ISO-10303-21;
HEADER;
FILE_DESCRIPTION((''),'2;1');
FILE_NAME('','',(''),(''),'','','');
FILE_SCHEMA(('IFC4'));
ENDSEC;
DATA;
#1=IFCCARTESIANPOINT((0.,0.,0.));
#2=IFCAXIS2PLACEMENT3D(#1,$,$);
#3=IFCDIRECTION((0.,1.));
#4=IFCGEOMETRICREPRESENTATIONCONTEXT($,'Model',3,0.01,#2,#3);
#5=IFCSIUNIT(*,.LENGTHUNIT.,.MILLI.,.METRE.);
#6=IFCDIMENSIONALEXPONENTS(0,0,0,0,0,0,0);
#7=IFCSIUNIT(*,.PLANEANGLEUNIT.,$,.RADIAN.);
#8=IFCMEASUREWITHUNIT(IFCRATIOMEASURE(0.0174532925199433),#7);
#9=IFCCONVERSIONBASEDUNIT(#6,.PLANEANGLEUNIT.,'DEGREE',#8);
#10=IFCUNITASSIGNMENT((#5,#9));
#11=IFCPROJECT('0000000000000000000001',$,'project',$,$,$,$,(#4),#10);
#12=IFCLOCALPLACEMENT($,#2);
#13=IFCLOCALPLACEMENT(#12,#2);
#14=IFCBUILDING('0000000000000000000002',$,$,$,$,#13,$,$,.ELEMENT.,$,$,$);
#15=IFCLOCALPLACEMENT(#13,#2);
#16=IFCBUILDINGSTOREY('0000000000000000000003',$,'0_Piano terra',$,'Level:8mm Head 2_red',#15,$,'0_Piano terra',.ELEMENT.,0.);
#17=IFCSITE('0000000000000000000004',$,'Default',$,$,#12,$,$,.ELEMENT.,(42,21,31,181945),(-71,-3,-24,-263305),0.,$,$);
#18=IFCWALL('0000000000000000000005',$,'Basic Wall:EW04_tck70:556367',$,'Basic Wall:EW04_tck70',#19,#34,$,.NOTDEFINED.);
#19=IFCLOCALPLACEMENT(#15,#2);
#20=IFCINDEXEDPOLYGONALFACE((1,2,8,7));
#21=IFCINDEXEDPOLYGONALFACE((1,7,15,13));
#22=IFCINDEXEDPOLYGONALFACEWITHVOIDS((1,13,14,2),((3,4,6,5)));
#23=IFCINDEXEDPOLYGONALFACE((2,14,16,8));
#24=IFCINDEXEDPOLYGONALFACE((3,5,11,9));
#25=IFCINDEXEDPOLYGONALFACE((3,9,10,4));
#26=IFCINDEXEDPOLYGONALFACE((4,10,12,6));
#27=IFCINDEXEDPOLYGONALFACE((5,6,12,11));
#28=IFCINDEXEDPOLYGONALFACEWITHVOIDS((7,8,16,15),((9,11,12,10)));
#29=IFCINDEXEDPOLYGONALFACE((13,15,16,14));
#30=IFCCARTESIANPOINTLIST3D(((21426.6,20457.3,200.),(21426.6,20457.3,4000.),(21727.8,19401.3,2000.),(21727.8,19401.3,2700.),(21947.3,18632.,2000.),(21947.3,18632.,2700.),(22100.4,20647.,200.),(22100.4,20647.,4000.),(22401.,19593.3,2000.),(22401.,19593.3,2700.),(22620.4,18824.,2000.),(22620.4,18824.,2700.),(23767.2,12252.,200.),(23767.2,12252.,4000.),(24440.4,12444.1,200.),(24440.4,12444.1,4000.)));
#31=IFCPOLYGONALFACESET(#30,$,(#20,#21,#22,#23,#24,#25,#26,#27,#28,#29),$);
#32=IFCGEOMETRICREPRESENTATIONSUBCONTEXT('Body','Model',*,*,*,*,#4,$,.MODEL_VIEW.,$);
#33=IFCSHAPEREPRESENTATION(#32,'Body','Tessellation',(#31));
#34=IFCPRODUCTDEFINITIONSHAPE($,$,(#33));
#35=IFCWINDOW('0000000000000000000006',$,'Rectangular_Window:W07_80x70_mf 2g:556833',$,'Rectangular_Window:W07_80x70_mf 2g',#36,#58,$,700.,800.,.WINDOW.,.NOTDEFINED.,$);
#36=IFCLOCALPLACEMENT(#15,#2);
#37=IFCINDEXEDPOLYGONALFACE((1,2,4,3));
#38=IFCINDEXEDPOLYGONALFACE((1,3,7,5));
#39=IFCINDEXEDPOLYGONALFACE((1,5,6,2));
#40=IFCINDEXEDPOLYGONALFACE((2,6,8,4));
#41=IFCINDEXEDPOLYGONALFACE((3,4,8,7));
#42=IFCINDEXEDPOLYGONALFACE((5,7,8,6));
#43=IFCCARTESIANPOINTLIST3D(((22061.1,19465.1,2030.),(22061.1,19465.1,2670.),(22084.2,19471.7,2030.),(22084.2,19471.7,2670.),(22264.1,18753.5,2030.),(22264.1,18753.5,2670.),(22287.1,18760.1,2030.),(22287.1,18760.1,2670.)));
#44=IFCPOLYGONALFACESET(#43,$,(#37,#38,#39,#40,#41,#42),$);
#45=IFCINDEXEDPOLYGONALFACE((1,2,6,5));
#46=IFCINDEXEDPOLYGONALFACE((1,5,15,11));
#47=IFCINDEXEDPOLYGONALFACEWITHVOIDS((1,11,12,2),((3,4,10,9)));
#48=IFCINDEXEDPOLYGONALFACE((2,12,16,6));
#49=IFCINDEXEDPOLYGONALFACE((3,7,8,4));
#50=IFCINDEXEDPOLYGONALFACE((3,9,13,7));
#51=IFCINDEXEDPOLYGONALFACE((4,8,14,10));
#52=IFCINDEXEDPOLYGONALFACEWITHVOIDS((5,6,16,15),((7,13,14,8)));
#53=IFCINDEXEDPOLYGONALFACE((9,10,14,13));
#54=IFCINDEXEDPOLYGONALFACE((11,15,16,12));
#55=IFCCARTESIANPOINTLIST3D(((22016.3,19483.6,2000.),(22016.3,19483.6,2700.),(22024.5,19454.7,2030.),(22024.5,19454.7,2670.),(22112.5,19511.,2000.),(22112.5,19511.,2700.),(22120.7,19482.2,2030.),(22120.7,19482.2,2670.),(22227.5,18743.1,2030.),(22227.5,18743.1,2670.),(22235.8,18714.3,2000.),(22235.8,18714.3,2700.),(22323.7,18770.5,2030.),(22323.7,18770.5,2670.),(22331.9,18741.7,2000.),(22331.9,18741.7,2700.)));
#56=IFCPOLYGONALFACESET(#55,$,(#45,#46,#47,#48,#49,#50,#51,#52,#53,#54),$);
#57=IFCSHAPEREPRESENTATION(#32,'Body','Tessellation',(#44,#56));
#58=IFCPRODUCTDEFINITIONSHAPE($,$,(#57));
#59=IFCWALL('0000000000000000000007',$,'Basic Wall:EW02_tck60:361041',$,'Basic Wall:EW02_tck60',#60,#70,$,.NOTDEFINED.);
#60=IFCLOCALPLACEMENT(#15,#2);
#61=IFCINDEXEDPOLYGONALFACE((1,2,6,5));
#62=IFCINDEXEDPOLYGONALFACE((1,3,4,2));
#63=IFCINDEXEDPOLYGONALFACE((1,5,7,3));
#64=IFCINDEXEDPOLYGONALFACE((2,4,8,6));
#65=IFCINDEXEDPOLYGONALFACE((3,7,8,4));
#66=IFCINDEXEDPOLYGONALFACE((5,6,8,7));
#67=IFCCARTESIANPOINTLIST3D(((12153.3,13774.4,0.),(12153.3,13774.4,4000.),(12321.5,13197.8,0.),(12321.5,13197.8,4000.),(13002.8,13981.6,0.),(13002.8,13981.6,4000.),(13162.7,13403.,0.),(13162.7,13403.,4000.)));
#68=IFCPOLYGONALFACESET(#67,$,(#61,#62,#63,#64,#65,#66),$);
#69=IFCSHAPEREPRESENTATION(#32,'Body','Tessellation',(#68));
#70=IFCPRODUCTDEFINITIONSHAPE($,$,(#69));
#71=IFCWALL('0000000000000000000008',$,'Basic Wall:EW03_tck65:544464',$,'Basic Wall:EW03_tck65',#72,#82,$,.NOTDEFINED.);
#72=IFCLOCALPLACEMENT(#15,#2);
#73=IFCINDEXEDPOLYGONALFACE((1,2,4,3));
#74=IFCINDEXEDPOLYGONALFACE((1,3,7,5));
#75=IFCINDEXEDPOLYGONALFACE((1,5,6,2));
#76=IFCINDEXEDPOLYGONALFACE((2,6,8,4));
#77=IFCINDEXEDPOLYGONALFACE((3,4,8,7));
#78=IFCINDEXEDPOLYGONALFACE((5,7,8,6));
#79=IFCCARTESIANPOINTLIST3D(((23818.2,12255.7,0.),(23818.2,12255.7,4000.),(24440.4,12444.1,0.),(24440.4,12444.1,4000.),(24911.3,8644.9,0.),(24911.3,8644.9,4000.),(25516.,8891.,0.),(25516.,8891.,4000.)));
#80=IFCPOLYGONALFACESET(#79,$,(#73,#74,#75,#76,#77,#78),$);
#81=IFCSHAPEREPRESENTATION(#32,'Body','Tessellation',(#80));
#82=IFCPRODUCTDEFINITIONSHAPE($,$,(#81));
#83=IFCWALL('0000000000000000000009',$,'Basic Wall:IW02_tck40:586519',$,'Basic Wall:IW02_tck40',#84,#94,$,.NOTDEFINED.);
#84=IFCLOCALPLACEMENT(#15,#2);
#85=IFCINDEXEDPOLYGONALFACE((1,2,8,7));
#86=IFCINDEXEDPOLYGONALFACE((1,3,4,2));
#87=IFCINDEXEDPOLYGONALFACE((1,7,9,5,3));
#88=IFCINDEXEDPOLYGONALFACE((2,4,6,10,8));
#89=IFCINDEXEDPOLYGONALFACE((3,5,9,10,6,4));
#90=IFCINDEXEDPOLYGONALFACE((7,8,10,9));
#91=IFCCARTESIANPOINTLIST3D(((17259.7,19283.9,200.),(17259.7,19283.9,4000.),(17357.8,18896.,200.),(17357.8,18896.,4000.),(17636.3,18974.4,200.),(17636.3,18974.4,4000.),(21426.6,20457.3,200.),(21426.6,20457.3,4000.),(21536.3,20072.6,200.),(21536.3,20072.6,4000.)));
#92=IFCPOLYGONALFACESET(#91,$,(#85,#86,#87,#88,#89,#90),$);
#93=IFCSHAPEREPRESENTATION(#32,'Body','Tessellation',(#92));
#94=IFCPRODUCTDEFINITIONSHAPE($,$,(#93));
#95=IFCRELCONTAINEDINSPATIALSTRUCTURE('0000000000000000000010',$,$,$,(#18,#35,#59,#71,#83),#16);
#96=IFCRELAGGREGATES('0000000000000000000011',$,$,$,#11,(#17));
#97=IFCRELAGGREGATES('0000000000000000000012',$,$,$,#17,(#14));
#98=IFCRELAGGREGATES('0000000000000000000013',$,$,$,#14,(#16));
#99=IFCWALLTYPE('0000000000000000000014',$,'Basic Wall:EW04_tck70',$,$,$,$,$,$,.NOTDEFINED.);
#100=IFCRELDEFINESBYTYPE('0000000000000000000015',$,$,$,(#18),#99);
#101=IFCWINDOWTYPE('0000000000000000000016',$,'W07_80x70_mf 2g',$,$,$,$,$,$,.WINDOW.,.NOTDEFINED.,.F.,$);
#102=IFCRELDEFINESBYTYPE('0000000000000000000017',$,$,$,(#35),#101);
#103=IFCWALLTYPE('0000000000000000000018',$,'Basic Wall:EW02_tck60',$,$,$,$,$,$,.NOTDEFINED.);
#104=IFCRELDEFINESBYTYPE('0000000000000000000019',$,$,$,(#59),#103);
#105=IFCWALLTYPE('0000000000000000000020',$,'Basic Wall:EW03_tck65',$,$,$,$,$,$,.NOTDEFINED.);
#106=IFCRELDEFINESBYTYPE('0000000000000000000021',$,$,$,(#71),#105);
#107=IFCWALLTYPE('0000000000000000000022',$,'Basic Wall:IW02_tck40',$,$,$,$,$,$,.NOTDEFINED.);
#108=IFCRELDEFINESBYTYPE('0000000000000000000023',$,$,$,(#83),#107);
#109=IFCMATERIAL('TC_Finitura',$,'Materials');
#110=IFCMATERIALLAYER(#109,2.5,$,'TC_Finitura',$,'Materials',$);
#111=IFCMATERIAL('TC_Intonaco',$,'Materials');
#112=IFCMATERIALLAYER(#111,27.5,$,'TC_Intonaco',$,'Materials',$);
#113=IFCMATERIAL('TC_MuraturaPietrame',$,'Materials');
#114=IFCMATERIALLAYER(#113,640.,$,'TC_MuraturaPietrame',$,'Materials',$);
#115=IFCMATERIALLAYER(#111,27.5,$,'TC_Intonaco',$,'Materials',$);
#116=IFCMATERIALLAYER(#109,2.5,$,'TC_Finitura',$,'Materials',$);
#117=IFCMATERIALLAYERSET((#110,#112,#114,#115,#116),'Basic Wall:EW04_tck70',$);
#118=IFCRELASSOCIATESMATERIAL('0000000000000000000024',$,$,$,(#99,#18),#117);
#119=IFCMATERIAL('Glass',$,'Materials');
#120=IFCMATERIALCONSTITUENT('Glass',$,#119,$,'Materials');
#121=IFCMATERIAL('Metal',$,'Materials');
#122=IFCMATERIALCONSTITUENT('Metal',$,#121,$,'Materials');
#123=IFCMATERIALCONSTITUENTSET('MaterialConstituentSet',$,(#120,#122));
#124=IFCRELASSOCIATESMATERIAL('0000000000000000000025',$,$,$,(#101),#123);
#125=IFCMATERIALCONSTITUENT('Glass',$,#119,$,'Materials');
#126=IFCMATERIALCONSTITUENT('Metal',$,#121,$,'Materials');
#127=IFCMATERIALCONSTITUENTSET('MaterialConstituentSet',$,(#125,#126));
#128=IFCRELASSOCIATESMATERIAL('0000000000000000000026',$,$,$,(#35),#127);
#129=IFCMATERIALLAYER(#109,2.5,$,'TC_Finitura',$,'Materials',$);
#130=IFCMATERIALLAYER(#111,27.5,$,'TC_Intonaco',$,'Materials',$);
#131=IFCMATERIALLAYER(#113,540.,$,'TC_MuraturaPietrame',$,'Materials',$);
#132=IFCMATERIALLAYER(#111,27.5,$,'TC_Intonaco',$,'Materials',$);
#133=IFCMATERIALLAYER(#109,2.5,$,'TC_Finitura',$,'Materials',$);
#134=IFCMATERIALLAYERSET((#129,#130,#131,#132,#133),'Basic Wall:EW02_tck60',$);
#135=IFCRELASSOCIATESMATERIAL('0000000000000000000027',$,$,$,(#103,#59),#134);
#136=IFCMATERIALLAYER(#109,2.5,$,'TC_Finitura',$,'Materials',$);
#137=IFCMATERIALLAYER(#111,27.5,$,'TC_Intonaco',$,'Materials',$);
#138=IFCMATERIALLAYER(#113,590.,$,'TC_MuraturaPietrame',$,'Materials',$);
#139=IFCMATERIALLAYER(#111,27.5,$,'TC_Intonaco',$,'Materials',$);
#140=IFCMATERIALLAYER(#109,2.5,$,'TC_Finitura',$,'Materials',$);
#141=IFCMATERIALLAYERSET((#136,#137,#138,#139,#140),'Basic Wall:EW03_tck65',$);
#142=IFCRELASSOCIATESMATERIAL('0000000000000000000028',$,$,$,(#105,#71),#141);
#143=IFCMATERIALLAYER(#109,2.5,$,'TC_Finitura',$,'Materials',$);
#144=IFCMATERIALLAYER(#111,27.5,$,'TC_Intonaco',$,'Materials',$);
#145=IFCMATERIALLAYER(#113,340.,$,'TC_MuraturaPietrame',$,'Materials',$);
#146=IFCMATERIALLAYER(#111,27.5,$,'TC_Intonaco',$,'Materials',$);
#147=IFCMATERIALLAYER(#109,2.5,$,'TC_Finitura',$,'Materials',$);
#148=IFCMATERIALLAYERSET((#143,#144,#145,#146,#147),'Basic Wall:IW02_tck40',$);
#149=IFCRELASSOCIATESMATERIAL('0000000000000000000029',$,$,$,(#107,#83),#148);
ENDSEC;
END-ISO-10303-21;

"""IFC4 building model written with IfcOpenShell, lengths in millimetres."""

from ifc_helpers import new_model, entity, si_unit, converted_unit, direction, frame, frame_2d, origin, origin_2d_with_axis, place, context, subcontext, project, spatial, polyline, rectangle, outline, extrude, clip, halfspace, bounded_halfspace, source, transform, mapped, material, layer, layer_set, layer_usage, constituent, constituent_set, type_object, type_shapes, element, fill, save


model = new_model("IFC4")

# Units and contexts
model_context = context("Model", 3, precision=0.01, world=origin(), true_north=direction((0.0, 1.0)))
body_context = subcontext(model_context, "Body", "Model", "MODEL_VIEW")
ifc_project = project(units=[si_unit("LENGTHUNIT", "METRE", prefix="MILLI"), converted_unit("PLANEANGLEUNIT", "DEGREE", entity("IfcRatioMeasure", 0.0174532925199433), si_unit("PLANEANGLEUNIT", "RADIAN"), dimensions=[0, 0, 0, 0, 0, 0, 0])], contexts=[model_context])

# Site, building, storey
site_placement = place(None, origin())
site = spatial("IfcSite", under=ifc_project, at=site_placement, Name="Default", CompositionType="ELEMENT", RefLatitude=(42, 21, 31, 181945), RefLongitude=(-71, -3, -24, -263305), RefElevation=0.0)
building_placement = place(site_placement, origin())
building = spatial("IfcBuilding", under=site, at=building_placement, CompositionType="ELEMENT")
storey_placement = place(building_placement, origin())
storey = spatial("IfcBuildingStorey", under=building, at=storey_placement, Name="0_Piano terra", ObjectType="Level:8mm Head 2_red", LongName="0_Piano terra", CompositionType="ELEMENT", Elevation=0.0)

# Shared definitions
ifc_material_1 = material(Name="TC_Finitura", Category="Materials")
ifc_material_2 = material(Name="TC_Intonaco", Category="Materials")
ifc_material_3 = material(Name="TC_MuraturaPietrame", Category="Materials")

# Shared definitions
ifc_material_4 = material(Name="Glass", Category="Materials")
ifc_material_5 = material(Name="Metal", Category="Materials")

# Wall, opening, window
ifc_layer_1 = layer(ifc_material_1, 2.5, Name="TC_Finitura", Category="Materials")
ifc_layer_2 = layer(ifc_material_2, 27.5, Name="TC_Intonaco", Category="Materials")
ifc_layer_3 = layer(ifc_material_3, 640.0, Name="TC_MuraturaPietrame", Category="Materials")
ifc_layer_4 = layer(ifc_material_2, 27.5, Name="TC_Intonaco", Category="Materials")
ifc_layer_5 = layer(ifc_material_1, 2.5, Name="TC_Finitura", Category="Materials")
ifc_layer_set_1 = layer_set([ifc_layer_1, ifc_layer_2, ifc_layer_3, ifc_layer_4, ifc_layer_5], Name="Basic Wall:EW04_tck70")
wall_type_1 = type_object("IfcWallType", Name="Basic Wall:EW04_tck70", PredefinedType="NOTDEFINED", material=ifc_layer_set_1)
ifc_layer_usage_1 = layer_usage(ifc_layer_set_1, "AXIS2", "NEGATIVE", 350.0)
wall_1_placement = place(storey_placement, frame((24103.8, 12348.1, 200.0), z_axis=(0.0, 0.0, 1.0), x_axis=(-0.274319, 0.961639, 0.0)))
wall_1 = element("IfcWall", 1, at=wall_1_placement, inside=storey, type_object=wall_type_1, material=ifc_layer_usage_1, Name="Basic Wall:EW04_tck70:556367", ObjectType="Basic Wall:EW04_tck70", PredefinedType="NOTDEFINED", context=body_context, shape_type="SweptSolid", body=[
    extrude(outline(polyline([(8530.1, -350.0), (8532.5, 350.0), (8132.5, 350.0), (4234.8, 350.0), (3634.4, 350.0), (0.0, 350.0), (0.0, -350.0), (8530.1, -350.0)])), origin(), (0.0, 0.0, 1.0), 3800.0),
])
opening_1_placement = place(wall_1_placement, frame((7434.4, 350.0, 1800.0)))
opening_1 = element("IfcOpeningElement", 2, at=opening_1_placement, cuts=wall_1, ObjectType="Opening", PredefinedType="OPENING", context=body_context, shape_type="SweptSolid", body=[
    extrude(rectangle(XDim=700.0, YDim=800.0, at=frame_2d((350.0, 400.0), x_axis=(-1.0, 0.0))), frame((0.0, 0.0, 0.0), z_axis=(0.0, -1.0, 0.0), x_axis=(0.0, 0.0, 1.0)), (0.0, 0.0, 1.0), 700.0),
])
ifc_constituent_1 = constituent(ifc_material_4, Name="Glass", Category="Materials")
ifc_constituent_2 = constituent(ifc_material_5, Name="Metal", Category="Materials")
ifc_constituent_set_1 = constituent_set(constituents=[ifc_constituent_1, ifc_constituent_2], Name="MaterialConstituentSet")
ifc_constituent_3 = constituent(ifc_material_4, Name="Glass", Category="Materials")
ifc_constituent_4 = constituent(ifc_material_5, Name="Metal", Category="Materials")
ifc_constituent_set_2 = constituent_set(constituents=[ifc_constituent_3, ifc_constituent_4], Name="MaterialConstituentSet")
window_type_1 = type_object("IfcWindowType", Name="W07_80x70_mf 2g", ParameterTakesPrecedence=False, PartitioningType="NOTDEFINED", PredefinedType="WINDOW", material=ifc_constituent_set_2)
shared_shape_1 = source(origin(), body_context, "Body", "SweptSolid", [
    extrude(rectangle(XDim=24.0, YDim=740.0, at=origin_2d_with_axis()), frame((400.0, 350.0, 30.0), z_axis=(0.0, 0.0, 1.0), x_axis=(0.0, 1.0, 0.0)), (0.0, 0.0, 1.0), 640.0),
    extrude(outline(polyline([(-400.0, -350.0), (400.0, -350.0), (400.0, 350.0), (-400.0, 350.0), (-400.0, -350.0)]), holes=[polyline([(-370.0, -320.0), (-370.0, 320.0), (370.0, 320.0), (370.0, -320.0), (-370.0, -320.0)])]), frame((400.0, 300.0, 350.0), z_axis=(0.0, 1.0, 0.0), x_axis=(1.0, 0.0, 0.0)), (0.0, 0.0, 1.0), 100.0),
])
type_shapes(window_type_1, [shared_shape_1])
window_1_placement = place(opening_1_placement, frame((0.0, 0.0, 0.0), z_axis=(0.0, 0.0, 1.0), x_axis=(-1.0, 0.0, 0.0)))
window_1 = element("IfcWindow", 3, at=window_1_placement, inside=storey, type_object=window_type_1, material=ifc_constituent_set_1, Name="Rectangular_Window:W07_80x70_mf 2g:556833", ObjectType="Rectangular_Window:W07_80x70_mf 2g", OverallHeight=700.0, OverallWidth=800.0, PartitioningType="NOTDEFINED", PredefinedType="WINDOW", context=body_context, shape_type="MappedRepresentation", body=[
    mapped(shared_shape_1, transform((0.0, 0.0, 0.0), scale=1.0)),
])
fill(opening_1, window_1)

# Wall
ifc_layer_6 = layer(ifc_material_1, 2.5, Name="TC_Finitura", Category="Materials")
ifc_layer_7 = layer(ifc_material_2, 27.5, Name="TC_Intonaco", Category="Materials")
ifc_layer_8 = layer(ifc_material_3, 540.0, Name="TC_MuraturaPietrame", Category="Materials")
ifc_layer_9 = layer(ifc_material_2, 27.5, Name="TC_Intonaco", Category="Materials")
ifc_layer_10 = layer(ifc_material_1, 2.5, Name="TC_Finitura", Category="Materials")
ifc_layer_set_2 = layer_set([ifc_layer_6, ifc_layer_7, ifc_layer_8, ifc_layer_9, ifc_layer_10], Name="Basic Wall:EW02_tck60")
ifc_layer_usage_2 = layer_usage(ifc_layer_set_2, "AXIS2", "NEGATIVE", 300.0)
wall_type_2 = type_object("IfcWallType", Name="Basic Wall:EW02_tck60", PredefinedType="NOTDEFINED", material=ifc_layer_set_2)
wall_2_placement = place(storey_placement, frame((12224.4, 13482.9, 0.0), z_axis=(0.0, 0.0, 1.0), x_axis=(0.971504, 0.237022, 0.0)))
element("IfcWall", 4, at=wall_2_placement, inside=storey, type_object=wall_type_2, material=ifc_layer_usage_2, Name="Basic Wall:EW02_tck60:361041", ObjectType="Basic Wall:EW02_tck60", PredefinedType="NOTDEFINED", context=body_context, shape_type="Clipping", body=[
    clip(extrude(outline(polyline([(892.6, -300.0), (874.4, 300.0), (274.1, 300.0), (0.0, 300.0), (0.0, 299.8), (26.7, -300.0), (892.6, -300.0)])), origin(), (0.0, 0.0, 1.0), 4000.0), bounded_halfspace(frame((26.7, -300.0, 4000.0), z_axis=(0.0, 0.0, -1.0), x_axis=(0.039314, -0.999227, 0.0)), True, frame((26.7, -300.0, 4000.0)), polyline([(0.0, 0.0), (865.9, 0.0), (847.7, 600.0), (247.4, 600.0), (-26.7, 600.0), (-26.7, 599.8), (0.0, 0.0)]))),
])

# Walls
ifc_layer_11 = layer(ifc_material_1, 2.5, Name="TC_Finitura", Category="Materials")
ifc_layer_12 = layer(ifc_material_2, 27.5, Name="TC_Intonaco", Category="Materials")
ifc_layer_13 = layer(ifc_material_3, 590.0, Name="TC_MuraturaPietrame", Category="Materials")
ifc_layer_14 = layer(ifc_material_2, 27.5, Name="TC_Intonaco", Category="Materials")
ifc_layer_15 = layer(ifc_material_1, 2.5, Name="TC_Finitura", Category="Materials")
ifc_layer_set_3 = layer_set([ifc_layer_11, ifc_layer_12, ifc_layer_13, ifc_layer_14, ifc_layer_15], Name="Basic Wall:EW03_tck65")
ifc_layer_usage_3 = layer_usage(ifc_layer_set_3, "AXIS2", "NEGATIVE", 325.0)
wall_type_3 = type_object("IfcWallType", Name="Basic Wall:EW03_tck65", PredefinedType="NOTDEFINED", material=ifc_layer_set_3)
wall_3_placement = place(storey_placement, frame((24129.3, 12349.9, 0.0), z_axis=(0.0, 0.0, 1.0), x_axis=(0.28974, -0.957105, 0.0)))
element("IfcWall", 5, at=wall_3_placement, inside=storey, type_object=wall_type_3, material=ifc_layer_usage_3, Name="Basic Wall:EW03_tck65:544464", ObjectType="Basic Wall:EW03_tck65", PredefinedType="NOTDEFINED", context=body_context, shape_type="Clipping", body=[
    clip(clip(extrude(outline(polyline([(3772.7, -325.0), (3712.3, 325.0), (0.0, 325.0), (0.0, -325.0), (179.1, -325.0), (780.7, -325.0), (3772.7, -325.0)])), origin(), (0.0, 0.0, 1.0), 4000.0), bounded_halfspace(frame((0.0, -325.0, 4000.0), z_axis=(0.0, 0.0, -1.0), x_axis=(0.999882, -0.015331, 0.0)), True, frame((0.0, -325.0, 4000.0)), polyline([(0.0, 0.0), (179.1, 0.0), (780.7, 0.0), (3772.7, 0.0), (3712.3, 650.0), (0.0, 650.0), (0.0, 0.0)]))), halfspace(frame((0.0, 0.0, -550.0)), True)),
])
ifc_layer_16 = layer(ifc_material_1, 2.5, Name="TC_Finitura", Category="Materials")
ifc_layer_17 = layer(ifc_material_2, 27.5, Name="TC_Intonaco", Category="Materials")
ifc_layer_18 = layer(ifc_material_3, 340.0, Name="TC_MuraturaPietrame", Category="Materials")
ifc_layer_19 = layer(ifc_material_2, 27.5, Name="TC_Intonaco", Category="Materials")
ifc_layer_20 = layer(ifc_material_1, 2.5, Name="TC_Finitura", Category="Materials")
ifc_layer_set_4 = layer_set([ifc_layer_16, ifc_layer_17, ifc_layer_18, ifc_layer_19, ifc_layer_20], Name="Basic Wall:IW02_tck40")
ifc_layer_usage_4 = layer_usage(ifc_layer_set_4, "AXIS2", "POSITIVE", -200.0)
wall_type_4 = type_object("IfcWallType", Name="Basic Wall:IW02_tck40", PredefinedType="NOTDEFINED", material=ifc_layer_set_4)
wall_4_placement = place(storey_placement, frame((21482.1, 20265.1, 200.0), z_axis=(0.0, 0.0, 1.0), x_axis=(-0.962567, -0.271045, 0.0)))
element("IfcWall", 6, at=wall_4_placement, inside=storey, type_object=wall_type_4, material=ifc_layer_usage_4, Name="Basic Wall:IW02_tck40:586519", ObjectType="Basic Wall:IW02_tck40", PredefinedType="NOTDEFINED", context=body_context, shape_type="SweptSolid", body=[
    extrude(outline(polyline([(4330.3, -200.0), (4341.0, 200.0), (4051.7, 200.0), (0.0, 200.0), (1.4, -200.0), (4330.3, -200.0)])), origin(), (0.0, 0.0, 1.0), 3800.0),
])

save(model, "model.ifc")
